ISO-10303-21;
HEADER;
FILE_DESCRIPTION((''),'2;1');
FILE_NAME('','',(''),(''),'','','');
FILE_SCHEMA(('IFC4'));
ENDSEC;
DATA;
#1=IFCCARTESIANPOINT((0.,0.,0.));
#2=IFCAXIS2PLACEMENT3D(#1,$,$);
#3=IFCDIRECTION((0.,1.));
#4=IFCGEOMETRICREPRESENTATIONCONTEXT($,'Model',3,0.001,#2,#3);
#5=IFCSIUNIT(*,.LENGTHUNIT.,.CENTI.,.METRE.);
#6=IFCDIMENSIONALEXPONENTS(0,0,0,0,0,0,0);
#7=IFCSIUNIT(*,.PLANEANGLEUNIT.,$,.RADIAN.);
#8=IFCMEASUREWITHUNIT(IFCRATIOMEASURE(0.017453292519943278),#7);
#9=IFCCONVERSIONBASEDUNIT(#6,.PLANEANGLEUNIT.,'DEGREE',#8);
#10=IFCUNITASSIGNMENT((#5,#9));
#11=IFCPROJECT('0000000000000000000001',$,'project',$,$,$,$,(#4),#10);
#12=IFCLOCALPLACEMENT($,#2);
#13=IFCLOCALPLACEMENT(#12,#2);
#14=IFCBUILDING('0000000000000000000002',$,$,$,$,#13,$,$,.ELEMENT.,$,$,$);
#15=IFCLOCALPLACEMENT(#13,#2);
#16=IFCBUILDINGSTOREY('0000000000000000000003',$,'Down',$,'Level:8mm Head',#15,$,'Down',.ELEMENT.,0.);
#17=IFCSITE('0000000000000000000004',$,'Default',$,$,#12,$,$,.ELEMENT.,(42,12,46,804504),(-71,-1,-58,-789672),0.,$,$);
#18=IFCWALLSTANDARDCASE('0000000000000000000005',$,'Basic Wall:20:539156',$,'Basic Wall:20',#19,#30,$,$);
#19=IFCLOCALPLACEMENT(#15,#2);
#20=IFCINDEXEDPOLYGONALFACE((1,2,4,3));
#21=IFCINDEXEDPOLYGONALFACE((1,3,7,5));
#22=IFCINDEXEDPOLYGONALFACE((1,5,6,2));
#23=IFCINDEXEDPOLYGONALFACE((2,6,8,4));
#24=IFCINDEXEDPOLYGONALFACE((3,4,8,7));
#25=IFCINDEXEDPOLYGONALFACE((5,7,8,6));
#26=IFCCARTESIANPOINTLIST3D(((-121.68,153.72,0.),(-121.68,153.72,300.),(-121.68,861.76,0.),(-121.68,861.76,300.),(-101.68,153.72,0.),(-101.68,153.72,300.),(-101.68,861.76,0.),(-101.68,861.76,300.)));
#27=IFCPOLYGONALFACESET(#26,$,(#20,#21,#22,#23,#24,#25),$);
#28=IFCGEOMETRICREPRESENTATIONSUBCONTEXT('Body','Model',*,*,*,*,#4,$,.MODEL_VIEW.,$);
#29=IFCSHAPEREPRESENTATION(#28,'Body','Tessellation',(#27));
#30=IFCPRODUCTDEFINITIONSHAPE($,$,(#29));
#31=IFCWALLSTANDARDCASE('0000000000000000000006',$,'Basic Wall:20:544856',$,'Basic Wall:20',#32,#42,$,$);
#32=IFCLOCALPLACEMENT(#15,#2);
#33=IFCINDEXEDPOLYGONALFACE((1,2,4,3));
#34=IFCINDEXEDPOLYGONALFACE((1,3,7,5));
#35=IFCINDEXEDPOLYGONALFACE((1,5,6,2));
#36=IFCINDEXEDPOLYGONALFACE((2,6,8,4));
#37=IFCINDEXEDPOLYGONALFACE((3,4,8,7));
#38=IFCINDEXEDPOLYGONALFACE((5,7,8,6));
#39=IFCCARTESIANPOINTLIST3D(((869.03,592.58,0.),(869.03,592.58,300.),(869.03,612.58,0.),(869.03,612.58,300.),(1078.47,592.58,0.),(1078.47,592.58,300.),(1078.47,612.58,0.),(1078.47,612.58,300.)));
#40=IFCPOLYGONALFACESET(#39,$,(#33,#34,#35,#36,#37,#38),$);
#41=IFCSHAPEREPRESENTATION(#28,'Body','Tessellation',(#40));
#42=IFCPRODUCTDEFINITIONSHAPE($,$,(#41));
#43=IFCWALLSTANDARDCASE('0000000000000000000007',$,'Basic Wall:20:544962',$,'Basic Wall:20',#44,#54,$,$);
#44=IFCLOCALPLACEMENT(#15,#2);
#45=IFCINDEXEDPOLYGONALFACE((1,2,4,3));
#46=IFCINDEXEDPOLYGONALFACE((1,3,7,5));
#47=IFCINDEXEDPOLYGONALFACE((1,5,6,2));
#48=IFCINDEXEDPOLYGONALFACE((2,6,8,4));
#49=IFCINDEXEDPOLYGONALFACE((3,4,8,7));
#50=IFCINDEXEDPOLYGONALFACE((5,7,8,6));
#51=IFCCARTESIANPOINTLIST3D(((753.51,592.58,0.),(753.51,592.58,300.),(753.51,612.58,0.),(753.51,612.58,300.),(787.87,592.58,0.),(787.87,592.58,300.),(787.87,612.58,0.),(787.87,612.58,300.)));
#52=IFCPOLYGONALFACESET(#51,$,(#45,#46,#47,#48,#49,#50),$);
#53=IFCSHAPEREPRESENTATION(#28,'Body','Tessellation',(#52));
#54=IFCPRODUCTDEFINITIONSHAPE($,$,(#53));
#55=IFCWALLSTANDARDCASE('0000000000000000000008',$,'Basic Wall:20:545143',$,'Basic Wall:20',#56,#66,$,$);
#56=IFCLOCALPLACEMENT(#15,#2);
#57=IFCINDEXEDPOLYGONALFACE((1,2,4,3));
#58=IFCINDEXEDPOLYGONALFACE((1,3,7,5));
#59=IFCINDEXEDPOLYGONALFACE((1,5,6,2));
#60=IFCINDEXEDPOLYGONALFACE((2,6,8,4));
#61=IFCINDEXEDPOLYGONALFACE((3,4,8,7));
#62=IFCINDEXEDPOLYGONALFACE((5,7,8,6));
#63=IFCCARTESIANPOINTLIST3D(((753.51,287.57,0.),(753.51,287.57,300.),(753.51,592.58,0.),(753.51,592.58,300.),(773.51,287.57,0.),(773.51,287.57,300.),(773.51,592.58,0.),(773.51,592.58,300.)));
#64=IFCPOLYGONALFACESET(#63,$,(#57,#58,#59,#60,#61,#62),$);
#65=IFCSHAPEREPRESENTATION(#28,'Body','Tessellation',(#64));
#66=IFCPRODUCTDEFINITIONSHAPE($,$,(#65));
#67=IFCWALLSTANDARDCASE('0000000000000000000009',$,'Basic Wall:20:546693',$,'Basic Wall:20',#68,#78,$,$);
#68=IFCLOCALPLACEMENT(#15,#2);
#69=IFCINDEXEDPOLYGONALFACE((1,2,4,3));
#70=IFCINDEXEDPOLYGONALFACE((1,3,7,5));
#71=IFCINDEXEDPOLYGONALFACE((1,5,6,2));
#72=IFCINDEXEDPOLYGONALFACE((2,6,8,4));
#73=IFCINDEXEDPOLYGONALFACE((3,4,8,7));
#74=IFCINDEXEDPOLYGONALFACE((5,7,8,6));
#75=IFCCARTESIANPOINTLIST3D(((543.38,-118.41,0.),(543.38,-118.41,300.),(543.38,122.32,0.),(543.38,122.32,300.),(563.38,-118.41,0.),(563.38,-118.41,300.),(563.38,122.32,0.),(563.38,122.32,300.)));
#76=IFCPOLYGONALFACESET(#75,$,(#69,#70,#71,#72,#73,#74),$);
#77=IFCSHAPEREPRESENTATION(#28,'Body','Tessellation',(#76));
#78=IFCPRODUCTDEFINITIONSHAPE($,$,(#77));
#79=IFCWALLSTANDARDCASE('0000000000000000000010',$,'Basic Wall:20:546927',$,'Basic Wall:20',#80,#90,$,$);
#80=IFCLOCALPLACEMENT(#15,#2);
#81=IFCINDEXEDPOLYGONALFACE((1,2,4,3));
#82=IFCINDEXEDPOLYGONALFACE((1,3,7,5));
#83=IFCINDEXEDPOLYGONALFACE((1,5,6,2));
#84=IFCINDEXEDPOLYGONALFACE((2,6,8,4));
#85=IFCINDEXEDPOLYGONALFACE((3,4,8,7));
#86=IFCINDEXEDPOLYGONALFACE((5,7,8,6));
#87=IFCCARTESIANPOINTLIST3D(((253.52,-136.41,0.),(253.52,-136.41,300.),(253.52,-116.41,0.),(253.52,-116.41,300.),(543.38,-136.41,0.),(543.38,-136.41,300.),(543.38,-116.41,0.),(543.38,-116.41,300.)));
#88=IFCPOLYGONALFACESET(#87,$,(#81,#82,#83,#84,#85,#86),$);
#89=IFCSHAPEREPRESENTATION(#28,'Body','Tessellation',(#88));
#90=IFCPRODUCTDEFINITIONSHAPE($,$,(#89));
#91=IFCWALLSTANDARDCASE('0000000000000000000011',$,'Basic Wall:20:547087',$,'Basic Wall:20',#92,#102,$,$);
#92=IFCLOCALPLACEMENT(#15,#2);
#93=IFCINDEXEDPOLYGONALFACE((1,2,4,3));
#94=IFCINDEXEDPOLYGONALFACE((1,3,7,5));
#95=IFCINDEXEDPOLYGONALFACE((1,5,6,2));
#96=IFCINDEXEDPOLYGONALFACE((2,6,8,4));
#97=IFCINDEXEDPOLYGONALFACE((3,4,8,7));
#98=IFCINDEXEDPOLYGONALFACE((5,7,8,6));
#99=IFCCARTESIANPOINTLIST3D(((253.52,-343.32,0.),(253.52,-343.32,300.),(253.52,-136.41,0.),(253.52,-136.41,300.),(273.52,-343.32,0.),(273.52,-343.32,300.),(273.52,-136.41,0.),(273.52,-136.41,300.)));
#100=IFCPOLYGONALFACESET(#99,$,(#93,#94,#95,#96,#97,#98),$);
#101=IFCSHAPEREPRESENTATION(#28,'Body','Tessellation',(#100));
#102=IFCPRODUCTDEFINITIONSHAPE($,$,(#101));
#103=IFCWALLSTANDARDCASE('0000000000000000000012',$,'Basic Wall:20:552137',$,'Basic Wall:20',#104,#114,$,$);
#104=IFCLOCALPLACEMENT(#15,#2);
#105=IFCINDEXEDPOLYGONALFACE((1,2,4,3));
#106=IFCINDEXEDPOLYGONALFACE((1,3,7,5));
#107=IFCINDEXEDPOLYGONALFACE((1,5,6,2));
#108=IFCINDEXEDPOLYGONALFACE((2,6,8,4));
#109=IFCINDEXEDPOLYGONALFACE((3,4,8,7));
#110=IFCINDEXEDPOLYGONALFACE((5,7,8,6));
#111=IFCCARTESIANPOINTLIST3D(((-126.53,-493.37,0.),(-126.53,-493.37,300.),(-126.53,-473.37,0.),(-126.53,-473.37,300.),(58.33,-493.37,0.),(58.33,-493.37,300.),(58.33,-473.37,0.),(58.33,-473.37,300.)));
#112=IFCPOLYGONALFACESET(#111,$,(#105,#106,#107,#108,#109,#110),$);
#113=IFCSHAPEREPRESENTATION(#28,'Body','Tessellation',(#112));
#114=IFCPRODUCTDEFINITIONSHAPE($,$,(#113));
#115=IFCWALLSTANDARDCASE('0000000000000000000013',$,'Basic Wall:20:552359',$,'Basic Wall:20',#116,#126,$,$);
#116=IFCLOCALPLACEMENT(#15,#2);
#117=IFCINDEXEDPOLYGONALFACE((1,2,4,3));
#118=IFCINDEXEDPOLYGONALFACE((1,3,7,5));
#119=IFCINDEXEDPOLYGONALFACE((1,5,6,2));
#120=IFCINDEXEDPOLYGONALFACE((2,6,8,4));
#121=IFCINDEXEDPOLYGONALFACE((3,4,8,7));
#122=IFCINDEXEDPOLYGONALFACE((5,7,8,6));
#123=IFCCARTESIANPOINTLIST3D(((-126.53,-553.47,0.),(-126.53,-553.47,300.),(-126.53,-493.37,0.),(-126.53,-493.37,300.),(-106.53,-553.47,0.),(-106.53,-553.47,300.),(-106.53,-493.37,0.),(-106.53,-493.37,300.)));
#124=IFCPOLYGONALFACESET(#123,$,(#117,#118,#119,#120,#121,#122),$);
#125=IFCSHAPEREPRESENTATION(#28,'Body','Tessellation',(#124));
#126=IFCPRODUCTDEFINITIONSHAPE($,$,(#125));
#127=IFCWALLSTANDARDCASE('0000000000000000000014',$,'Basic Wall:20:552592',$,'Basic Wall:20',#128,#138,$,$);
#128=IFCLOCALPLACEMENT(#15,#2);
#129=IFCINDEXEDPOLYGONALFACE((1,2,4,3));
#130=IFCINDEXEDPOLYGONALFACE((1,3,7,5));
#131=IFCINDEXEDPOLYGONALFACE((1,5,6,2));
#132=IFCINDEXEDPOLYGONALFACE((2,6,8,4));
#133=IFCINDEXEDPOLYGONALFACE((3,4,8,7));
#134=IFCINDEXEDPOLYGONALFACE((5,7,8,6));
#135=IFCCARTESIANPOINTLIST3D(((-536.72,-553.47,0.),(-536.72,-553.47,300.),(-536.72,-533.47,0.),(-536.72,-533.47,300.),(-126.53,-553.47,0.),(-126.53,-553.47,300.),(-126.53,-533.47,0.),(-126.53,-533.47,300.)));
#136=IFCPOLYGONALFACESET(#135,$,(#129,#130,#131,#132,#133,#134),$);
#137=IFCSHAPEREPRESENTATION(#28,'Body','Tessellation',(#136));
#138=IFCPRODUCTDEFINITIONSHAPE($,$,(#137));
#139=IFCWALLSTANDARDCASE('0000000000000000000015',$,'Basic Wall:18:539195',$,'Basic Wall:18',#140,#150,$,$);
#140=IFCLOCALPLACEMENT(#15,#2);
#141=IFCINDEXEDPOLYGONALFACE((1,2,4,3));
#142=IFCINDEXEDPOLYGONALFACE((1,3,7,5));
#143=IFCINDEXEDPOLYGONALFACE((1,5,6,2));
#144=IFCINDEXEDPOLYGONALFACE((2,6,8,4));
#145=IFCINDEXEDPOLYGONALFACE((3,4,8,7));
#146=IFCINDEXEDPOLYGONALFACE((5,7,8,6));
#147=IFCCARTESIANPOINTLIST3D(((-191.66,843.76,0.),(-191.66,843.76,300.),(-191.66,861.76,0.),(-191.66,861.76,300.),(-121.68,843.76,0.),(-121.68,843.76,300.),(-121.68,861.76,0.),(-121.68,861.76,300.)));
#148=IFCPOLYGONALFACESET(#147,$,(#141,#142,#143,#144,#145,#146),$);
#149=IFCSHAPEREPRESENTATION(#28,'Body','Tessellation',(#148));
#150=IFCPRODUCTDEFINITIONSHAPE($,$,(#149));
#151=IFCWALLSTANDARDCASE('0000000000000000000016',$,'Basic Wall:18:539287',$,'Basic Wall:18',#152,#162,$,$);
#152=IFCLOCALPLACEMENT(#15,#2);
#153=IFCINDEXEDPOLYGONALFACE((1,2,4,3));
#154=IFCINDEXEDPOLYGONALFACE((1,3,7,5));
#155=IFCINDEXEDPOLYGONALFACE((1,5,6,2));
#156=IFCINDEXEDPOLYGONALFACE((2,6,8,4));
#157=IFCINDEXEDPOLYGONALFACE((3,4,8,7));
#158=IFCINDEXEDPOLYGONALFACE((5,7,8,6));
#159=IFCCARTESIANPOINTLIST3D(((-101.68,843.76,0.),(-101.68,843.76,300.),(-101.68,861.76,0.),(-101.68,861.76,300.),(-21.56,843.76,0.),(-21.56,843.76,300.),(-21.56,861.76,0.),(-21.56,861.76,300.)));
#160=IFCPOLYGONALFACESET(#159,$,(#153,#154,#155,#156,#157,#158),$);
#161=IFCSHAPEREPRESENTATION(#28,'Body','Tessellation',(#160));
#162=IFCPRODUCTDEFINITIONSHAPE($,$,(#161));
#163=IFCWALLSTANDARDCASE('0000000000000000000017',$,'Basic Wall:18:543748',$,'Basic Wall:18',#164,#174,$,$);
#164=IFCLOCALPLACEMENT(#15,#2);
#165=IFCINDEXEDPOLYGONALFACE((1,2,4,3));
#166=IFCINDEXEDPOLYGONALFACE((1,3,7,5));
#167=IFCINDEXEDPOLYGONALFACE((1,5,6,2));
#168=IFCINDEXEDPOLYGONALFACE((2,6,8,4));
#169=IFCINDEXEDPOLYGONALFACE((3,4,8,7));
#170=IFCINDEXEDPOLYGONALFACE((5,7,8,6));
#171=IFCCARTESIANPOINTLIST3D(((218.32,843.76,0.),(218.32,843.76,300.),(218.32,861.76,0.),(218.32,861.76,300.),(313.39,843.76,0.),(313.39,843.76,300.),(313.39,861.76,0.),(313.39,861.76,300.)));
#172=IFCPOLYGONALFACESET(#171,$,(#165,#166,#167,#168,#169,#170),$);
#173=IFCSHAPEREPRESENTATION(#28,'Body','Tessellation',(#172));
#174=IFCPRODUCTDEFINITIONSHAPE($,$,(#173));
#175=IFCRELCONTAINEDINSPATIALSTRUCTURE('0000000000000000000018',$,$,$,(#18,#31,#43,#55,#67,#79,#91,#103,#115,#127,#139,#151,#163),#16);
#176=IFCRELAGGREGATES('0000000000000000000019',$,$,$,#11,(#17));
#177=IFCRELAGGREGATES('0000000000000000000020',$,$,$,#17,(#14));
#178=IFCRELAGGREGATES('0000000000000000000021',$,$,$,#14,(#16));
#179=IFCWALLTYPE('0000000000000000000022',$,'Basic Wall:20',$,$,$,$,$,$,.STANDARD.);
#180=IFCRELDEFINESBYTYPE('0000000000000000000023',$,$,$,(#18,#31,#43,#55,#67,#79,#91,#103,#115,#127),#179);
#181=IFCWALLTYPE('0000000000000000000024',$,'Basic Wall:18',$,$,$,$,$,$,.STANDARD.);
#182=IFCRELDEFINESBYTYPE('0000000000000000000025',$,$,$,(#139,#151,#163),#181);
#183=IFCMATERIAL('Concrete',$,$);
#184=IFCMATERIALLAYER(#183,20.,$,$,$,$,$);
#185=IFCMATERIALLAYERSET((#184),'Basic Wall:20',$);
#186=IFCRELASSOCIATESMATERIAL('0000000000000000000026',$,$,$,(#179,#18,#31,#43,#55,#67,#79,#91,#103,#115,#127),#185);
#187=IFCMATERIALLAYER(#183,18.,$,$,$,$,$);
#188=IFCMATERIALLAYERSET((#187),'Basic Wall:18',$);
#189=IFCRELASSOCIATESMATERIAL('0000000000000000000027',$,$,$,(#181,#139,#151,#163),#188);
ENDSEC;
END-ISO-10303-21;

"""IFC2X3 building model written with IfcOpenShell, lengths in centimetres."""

from ifc_helpers import new_model, entity, si_unit, converted_unit, direction, frame, frame_2d, origin, place, context, subcontext, project, spatial, rectangle, extrude, material, layer, layer_set, layer_usage, type_object, element, save


model = new_model("IFC2X3")

# Units and contexts
model_context = context("Model", 3, precision=0.001, world=origin(), true_north=direction((0.0, 1.0)))
body_context = subcontext(model_context, "Body", "Model", "MODEL_VIEW")
ifc_project = project(units=[si_unit("LENGTHUNIT", "METRE", prefix="CENTI"), converted_unit("PLANEANGLEUNIT", "DEGREE", entity("IfcRatioMeasure", 0.017453292519943278), si_unit("PLANEANGLEUNIT", "RADIAN"), dimensions=[0, 0, 0, 0, 0, 0, 0])], contexts=[model_context])

# Site, building, storey
site_placement = place(None, origin())
site = spatial("IfcSite", under=ifc_project, at=site_placement, Name="Default", CompositionType="ELEMENT", RefLatitude=(42, 12, 46, 804504), RefLongitude=(-71, -1, -58, -789672), RefElevation=0.0)
building_placement = place(site_placement, origin())
building = spatial("IfcBuilding", under=site, at=building_placement, CompositionType="ELEMENT")
storey_placement = place(building_placement, origin())
storey = spatial("IfcBuildingStorey", under=building, at=storey_placement, Name="Down", ObjectType="Level:8mm Head", LongName="Down", CompositionType="ELEMENT", Elevation=0.0)

# Walls
ifc_material = material(Name="Concrete")
ifc_layer_1 = layer(ifc_material, 20.0)
ifc_layer_set_1 = layer_set([ifc_layer_1], Name="Basic Wall:20")
ifc_layer_usage_1 = layer_usage(ifc_layer_set_1, "AXIS2", "NEGATIVE", 10.0)
wall_type_1 = type_object("IfcWallType", Name="Basic Wall:20", PredefinedType="STANDARD", material=ifc_layer_set_1)
wall_1_placement = place(storey_placement, frame((-111.68, 153.72, 0.0), z_axis=(0.0, 0.0, 1.0), x_axis=(0.0, 1.0, 0.0)))
element("IfcWallStandardCase", 1, at=wall_1_placement, inside=storey, type_object=wall_type_1, material=ifc_layer_usage_1, Name="Basic Wall:20:539156", ObjectType="Basic Wall:20", context=body_context, shape_type="SweptSolid", body=[
    extrude(rectangle(XDim=708.04, YDim=20.0, at=frame_2d((354.02, 0.0), x_axis=(-1.0, 0.0))), origin(), (0.0, 0.0, 1.0), 300.0),
])
ifc_layer_usage_2 = layer_usage(ifc_layer_set_1, "AXIS2", "NEGATIVE", 10.0)
wall_2_placement = place(storey_placement, frame((1078.47, 602.58, 0.0), z_axis=(0.0, 0.0, 1.0), x_axis=(-1.0, 0.0, 0.0)))
element("IfcWallStandardCase", 2, at=wall_2_placement, inside=storey, type_object=wall_type_1, material=ifc_layer_usage_2, Name="Basic Wall:20:544856", ObjectType="Basic Wall:20", context=body_context, shape_type="SweptSolid", body=[
    extrude(rectangle(XDim=209.44, YDim=20.0, at=frame_2d((104.72, 0.0), x_axis=(-1.0, 0.0))), origin(), (0.0, 0.0, 1.0), 300.0),
])
ifc_layer_usage_3 = layer_usage(ifc_layer_set_1, "AXIS2", "NEGATIVE", 10.0)
wall_3_placement = place(storey_placement, frame((787.87, 602.58, 0.0), z_axis=(0.0, 0.0, 1.0), x_axis=(-1.0, 0.0, 0.0)))
element("IfcWallStandardCase", 3, at=wall_3_placement, inside=storey, type_object=wall_type_1, material=ifc_layer_usage_3, Name="Basic Wall:20:544962", ObjectType="Basic Wall:20", context=body_context, shape_type="SweptSolid", body=[
    extrude(rectangle(XDim=34.36, YDim=20.0, at=frame_2d((17.18, 0.0), x_axis=(-1.0, 0.0))), origin(), (0.0, 0.0, 1.0), 300.0),
])
ifc_layer_usage_4 = layer_usage(ifc_layer_set_1, "AXIS2", "POSITIVE", -10.0)
wall_4_placement = place(storey_placement, frame((763.51, 592.58, 0.0), z_axis=(0.0, 0.0, 1.0), x_axis=(0.0, -1.0, 0.0)))
element("IfcWallStandardCase", 4, at=wall_4_placement, inside=storey, type_object=wall_type_1, material=ifc_layer_usage_4, Name="Basic Wall:20:545143", ObjectType="Basic Wall:20", context=body_context, shape_type="SweptSolid", body=[
    extrude(rectangle(XDim=305.01, YDim=20.0, at=frame_2d((152.51, 0.0), x_axis=(-1.0, 0.0))), origin(), (0.0, 0.0, 1.0), 300.0),
])
ifc_layer_usage_5 = layer_usage(ifc_layer_set_1, "AXIS2", "NEGATIVE", 10.0)
wall_5_placement = place(storey_placement, frame((553.38, 122.32, 0.0), z_axis=(0.0, 0.0, 1.0), x_axis=(0.0, -1.0, 0.0)))
element("IfcWallStandardCase", 5, at=wall_5_placement, inside=storey, type_object=wall_type_1, material=ifc_layer_usage_5, Name="Basic Wall:20:546693", ObjectType="Basic Wall:20", context=body_context, shape_type="SweptSolid", body=[
    extrude(rectangle(XDim=240.72, YDim=20.0, at=frame_2d((120.36, 0.0), x_axis=(-1.0, 0.0))), origin(), (0.0, 0.0, 1.0), 300.0),
])
ifc_layer_usage_6 = layer_usage(ifc_layer_set_1, "AXIS2", "NEGATIVE", 10.0)
wall_6_placement = place(storey_placement, frame((543.38, -126.41, 0.0), z_axis=(0.0, 0.0, 1.0), x_axis=(-1.0, 0.0, 0.0)))
element("IfcWallStandardCase", 6, at=wall_6_placement, inside=storey, type_object=wall_type_1, material=ifc_layer_usage_6, Name="Basic Wall:20:546927", ObjectType="Basic Wall:20", context=body_context, shape_type="SweptSolid", body=[
    extrude(rectangle(XDim=289.86, YDim=20.0, at=frame_2d((144.93, 0.0), x_axis=(-1.0, 0.0))), origin(), (0.0, 0.0, 1.0), 300.0),
])
ifc_layer_usage_7 = layer_usage(ifc_layer_set_1, "AXIS2", "POSITIVE", -10.0)
wall_7_placement = place(storey_placement, frame((263.52, -136.41, 0.0), z_axis=(0.0, 0.0, 1.0), x_axis=(0.0, -1.0, 0.0)))
element("IfcWallStandardCase", 7, at=wall_7_placement, inside=storey, type_object=wall_type_1, material=ifc_layer_usage_7, Name="Basic Wall:20:547087", ObjectType="Basic Wall:20", context=body_context, shape_type="SweptSolid", body=[
    extrude(rectangle(XDim=206.91, YDim=20.0, at=frame_2d((103.46, 0.0), x_axis=(-1.0, 0.0))), origin(), (0.0, 0.0, 1.0), 300.0),
])
ifc_layer_usage_8 = layer_usage(ifc_layer_set_1, "AXIS2", "POSITIVE", -10.0)
wall_8_placement = place(storey_placement, frame((58.33, -483.37, 0.0), z_axis=(0.0, 0.0, 1.0), x_axis=(-1.0, 0.0, 0.0)))
element("IfcWallStandardCase", 8, at=wall_8_placement, inside=storey, type_object=wall_type_1, material=ifc_layer_usage_8, Name="Basic Wall:20:552137", ObjectType="Basic Wall:20", context=body_context, shape_type="SweptSolid", body=[
    extrude(rectangle(XDim=184.86, YDim=20.0, at=frame_2d((92.43, 0.0), x_axis=(-1.0, 0.0))), origin(), (0.0, 0.0, 1.0), 300.0),
])
ifc_layer_usage_9 = layer_usage(ifc_layer_set_1, "AXIS2", "POSITIVE", -10.0)
wall_9_placement = place(storey_placement, frame((-116.53, -493.37, 0.0), z_axis=(0.0, 0.0, 1.0), x_axis=(0.0, -1.0, 0.0)))
element("IfcWallStandardCase", 9, at=wall_9_placement, inside=storey, type_object=wall_type_1, material=ifc_layer_usage_9, Name="Basic Wall:20:552359", ObjectType="Basic Wall:20", context=body_context, shape_type="SweptSolid", body=[
    extrude(rectangle(XDim=60.1, YDim=20.0, at=frame_2d((30.05, 0.0), x_axis=(-1.0, 0.0))), origin(), (0.0, 0.0, 1.0), 300.0),
])
ifc_layer_usage_10 = layer_usage(ifc_layer_set_1, "AXIS2", "NEGATIVE", 10.0)
wall_10_placement = place(storey_placement, frame((-126.53, -543.47, 0.0), z_axis=(0.0, 0.0, 1.0), x_axis=(-1.0, 0.0, 0.0)))
element("IfcWallStandardCase", 10, at=wall_10_placement, inside=storey, type_object=wall_type_1, material=ifc_layer_usage_10, Name="Basic Wall:20:552592", ObjectType="Basic Wall:20", context=body_context, shape_type="SweptSolid", body=[
    extrude(rectangle(XDim=410.19, YDim=20.0, at=frame_2d((205.1, 0.0), x_axis=(-1.0, 0.0))), origin(), (0.0, 0.0, 1.0), 300.0),
])
ifc_layer_2 = layer(ifc_material, 18.0)
ifc_layer_set_2 = layer_set([ifc_layer_2], Name="Basic Wall:18")
ifc_layer_usage_11 = layer_usage(ifc_layer_set_2, "AXIS2", "POSITIVE", -9.0)
wall_type_2 = type_object("IfcWallType", Name="Basic Wall:18", PredefinedType="STANDARD", material=ifc_layer_set_2)
wall_11_placement = place(storey_placement, frame((-121.68, 852.76, 0.0), z_axis=(0.0, 0.0, 1.0), x_axis=(-1.0, 0.0, 0.0)))
element("IfcWallStandardCase", 11, at=wall_11_placement, inside=storey, type_object=wall_type_2, material=ifc_layer_usage_11, Name="Basic Wall:18:539195", ObjectType="Basic Wall:18", context=body_context, shape_type="SweptSolid", body=[
    extrude(rectangle(XDim=69.98, YDim=18.0, at=frame_2d((34.99, 0.0), x_axis=(-1.0, 0.0))), origin(), (0.0, 0.0, 1.0), 300.0),
])
ifc_layer_usage_12 = layer_usage(ifc_layer_set_2, "AXIS2", "NEGATIVE", 9.0)
wall_12_placement = place(storey_placement, frame((-101.68, 852.76, 0.0)))
element("IfcWallStandardCase", 12, at=wall_12_placement, inside=storey, type_object=wall_type_2, material=ifc_layer_usage_12, Name="Basic Wall:18:539287", ObjectType="Basic Wall:18", context=body_context, shape_type="SweptSolid", body=[
    extrude(rectangle(XDim=80.12, YDim=18.0, at=frame_2d((40.06, 0.0), x_axis=(-1.0, 0.0))), origin(), (0.0, 0.0, 1.0), 300.0),
])
ifc_layer_usage_13 = layer_usage(ifc_layer_set_2, "AXIS2", "NEGATIVE", 9.0)
wall_13_placement = place(storey_placement, frame((218.32, 852.76, 0.0)))
element("IfcWallStandardCase", 13, at=wall_13_placement, inside=storey, type_object=wall_type_2, material=ifc_layer_usage_13, Name="Basic Wall:18:543748", ObjectType="Basic Wall:18", context=body_context, shape_type="SweptSolid", body=[
    extrude(rectangle(XDim=95.07, YDim=18.0, at=frame_2d((47.53, 0.0), x_axis=(-1.0, 0.0))), origin(), (0.0, 0.0, 1.0), 300.0),
])

save(model, "model.ifc")
